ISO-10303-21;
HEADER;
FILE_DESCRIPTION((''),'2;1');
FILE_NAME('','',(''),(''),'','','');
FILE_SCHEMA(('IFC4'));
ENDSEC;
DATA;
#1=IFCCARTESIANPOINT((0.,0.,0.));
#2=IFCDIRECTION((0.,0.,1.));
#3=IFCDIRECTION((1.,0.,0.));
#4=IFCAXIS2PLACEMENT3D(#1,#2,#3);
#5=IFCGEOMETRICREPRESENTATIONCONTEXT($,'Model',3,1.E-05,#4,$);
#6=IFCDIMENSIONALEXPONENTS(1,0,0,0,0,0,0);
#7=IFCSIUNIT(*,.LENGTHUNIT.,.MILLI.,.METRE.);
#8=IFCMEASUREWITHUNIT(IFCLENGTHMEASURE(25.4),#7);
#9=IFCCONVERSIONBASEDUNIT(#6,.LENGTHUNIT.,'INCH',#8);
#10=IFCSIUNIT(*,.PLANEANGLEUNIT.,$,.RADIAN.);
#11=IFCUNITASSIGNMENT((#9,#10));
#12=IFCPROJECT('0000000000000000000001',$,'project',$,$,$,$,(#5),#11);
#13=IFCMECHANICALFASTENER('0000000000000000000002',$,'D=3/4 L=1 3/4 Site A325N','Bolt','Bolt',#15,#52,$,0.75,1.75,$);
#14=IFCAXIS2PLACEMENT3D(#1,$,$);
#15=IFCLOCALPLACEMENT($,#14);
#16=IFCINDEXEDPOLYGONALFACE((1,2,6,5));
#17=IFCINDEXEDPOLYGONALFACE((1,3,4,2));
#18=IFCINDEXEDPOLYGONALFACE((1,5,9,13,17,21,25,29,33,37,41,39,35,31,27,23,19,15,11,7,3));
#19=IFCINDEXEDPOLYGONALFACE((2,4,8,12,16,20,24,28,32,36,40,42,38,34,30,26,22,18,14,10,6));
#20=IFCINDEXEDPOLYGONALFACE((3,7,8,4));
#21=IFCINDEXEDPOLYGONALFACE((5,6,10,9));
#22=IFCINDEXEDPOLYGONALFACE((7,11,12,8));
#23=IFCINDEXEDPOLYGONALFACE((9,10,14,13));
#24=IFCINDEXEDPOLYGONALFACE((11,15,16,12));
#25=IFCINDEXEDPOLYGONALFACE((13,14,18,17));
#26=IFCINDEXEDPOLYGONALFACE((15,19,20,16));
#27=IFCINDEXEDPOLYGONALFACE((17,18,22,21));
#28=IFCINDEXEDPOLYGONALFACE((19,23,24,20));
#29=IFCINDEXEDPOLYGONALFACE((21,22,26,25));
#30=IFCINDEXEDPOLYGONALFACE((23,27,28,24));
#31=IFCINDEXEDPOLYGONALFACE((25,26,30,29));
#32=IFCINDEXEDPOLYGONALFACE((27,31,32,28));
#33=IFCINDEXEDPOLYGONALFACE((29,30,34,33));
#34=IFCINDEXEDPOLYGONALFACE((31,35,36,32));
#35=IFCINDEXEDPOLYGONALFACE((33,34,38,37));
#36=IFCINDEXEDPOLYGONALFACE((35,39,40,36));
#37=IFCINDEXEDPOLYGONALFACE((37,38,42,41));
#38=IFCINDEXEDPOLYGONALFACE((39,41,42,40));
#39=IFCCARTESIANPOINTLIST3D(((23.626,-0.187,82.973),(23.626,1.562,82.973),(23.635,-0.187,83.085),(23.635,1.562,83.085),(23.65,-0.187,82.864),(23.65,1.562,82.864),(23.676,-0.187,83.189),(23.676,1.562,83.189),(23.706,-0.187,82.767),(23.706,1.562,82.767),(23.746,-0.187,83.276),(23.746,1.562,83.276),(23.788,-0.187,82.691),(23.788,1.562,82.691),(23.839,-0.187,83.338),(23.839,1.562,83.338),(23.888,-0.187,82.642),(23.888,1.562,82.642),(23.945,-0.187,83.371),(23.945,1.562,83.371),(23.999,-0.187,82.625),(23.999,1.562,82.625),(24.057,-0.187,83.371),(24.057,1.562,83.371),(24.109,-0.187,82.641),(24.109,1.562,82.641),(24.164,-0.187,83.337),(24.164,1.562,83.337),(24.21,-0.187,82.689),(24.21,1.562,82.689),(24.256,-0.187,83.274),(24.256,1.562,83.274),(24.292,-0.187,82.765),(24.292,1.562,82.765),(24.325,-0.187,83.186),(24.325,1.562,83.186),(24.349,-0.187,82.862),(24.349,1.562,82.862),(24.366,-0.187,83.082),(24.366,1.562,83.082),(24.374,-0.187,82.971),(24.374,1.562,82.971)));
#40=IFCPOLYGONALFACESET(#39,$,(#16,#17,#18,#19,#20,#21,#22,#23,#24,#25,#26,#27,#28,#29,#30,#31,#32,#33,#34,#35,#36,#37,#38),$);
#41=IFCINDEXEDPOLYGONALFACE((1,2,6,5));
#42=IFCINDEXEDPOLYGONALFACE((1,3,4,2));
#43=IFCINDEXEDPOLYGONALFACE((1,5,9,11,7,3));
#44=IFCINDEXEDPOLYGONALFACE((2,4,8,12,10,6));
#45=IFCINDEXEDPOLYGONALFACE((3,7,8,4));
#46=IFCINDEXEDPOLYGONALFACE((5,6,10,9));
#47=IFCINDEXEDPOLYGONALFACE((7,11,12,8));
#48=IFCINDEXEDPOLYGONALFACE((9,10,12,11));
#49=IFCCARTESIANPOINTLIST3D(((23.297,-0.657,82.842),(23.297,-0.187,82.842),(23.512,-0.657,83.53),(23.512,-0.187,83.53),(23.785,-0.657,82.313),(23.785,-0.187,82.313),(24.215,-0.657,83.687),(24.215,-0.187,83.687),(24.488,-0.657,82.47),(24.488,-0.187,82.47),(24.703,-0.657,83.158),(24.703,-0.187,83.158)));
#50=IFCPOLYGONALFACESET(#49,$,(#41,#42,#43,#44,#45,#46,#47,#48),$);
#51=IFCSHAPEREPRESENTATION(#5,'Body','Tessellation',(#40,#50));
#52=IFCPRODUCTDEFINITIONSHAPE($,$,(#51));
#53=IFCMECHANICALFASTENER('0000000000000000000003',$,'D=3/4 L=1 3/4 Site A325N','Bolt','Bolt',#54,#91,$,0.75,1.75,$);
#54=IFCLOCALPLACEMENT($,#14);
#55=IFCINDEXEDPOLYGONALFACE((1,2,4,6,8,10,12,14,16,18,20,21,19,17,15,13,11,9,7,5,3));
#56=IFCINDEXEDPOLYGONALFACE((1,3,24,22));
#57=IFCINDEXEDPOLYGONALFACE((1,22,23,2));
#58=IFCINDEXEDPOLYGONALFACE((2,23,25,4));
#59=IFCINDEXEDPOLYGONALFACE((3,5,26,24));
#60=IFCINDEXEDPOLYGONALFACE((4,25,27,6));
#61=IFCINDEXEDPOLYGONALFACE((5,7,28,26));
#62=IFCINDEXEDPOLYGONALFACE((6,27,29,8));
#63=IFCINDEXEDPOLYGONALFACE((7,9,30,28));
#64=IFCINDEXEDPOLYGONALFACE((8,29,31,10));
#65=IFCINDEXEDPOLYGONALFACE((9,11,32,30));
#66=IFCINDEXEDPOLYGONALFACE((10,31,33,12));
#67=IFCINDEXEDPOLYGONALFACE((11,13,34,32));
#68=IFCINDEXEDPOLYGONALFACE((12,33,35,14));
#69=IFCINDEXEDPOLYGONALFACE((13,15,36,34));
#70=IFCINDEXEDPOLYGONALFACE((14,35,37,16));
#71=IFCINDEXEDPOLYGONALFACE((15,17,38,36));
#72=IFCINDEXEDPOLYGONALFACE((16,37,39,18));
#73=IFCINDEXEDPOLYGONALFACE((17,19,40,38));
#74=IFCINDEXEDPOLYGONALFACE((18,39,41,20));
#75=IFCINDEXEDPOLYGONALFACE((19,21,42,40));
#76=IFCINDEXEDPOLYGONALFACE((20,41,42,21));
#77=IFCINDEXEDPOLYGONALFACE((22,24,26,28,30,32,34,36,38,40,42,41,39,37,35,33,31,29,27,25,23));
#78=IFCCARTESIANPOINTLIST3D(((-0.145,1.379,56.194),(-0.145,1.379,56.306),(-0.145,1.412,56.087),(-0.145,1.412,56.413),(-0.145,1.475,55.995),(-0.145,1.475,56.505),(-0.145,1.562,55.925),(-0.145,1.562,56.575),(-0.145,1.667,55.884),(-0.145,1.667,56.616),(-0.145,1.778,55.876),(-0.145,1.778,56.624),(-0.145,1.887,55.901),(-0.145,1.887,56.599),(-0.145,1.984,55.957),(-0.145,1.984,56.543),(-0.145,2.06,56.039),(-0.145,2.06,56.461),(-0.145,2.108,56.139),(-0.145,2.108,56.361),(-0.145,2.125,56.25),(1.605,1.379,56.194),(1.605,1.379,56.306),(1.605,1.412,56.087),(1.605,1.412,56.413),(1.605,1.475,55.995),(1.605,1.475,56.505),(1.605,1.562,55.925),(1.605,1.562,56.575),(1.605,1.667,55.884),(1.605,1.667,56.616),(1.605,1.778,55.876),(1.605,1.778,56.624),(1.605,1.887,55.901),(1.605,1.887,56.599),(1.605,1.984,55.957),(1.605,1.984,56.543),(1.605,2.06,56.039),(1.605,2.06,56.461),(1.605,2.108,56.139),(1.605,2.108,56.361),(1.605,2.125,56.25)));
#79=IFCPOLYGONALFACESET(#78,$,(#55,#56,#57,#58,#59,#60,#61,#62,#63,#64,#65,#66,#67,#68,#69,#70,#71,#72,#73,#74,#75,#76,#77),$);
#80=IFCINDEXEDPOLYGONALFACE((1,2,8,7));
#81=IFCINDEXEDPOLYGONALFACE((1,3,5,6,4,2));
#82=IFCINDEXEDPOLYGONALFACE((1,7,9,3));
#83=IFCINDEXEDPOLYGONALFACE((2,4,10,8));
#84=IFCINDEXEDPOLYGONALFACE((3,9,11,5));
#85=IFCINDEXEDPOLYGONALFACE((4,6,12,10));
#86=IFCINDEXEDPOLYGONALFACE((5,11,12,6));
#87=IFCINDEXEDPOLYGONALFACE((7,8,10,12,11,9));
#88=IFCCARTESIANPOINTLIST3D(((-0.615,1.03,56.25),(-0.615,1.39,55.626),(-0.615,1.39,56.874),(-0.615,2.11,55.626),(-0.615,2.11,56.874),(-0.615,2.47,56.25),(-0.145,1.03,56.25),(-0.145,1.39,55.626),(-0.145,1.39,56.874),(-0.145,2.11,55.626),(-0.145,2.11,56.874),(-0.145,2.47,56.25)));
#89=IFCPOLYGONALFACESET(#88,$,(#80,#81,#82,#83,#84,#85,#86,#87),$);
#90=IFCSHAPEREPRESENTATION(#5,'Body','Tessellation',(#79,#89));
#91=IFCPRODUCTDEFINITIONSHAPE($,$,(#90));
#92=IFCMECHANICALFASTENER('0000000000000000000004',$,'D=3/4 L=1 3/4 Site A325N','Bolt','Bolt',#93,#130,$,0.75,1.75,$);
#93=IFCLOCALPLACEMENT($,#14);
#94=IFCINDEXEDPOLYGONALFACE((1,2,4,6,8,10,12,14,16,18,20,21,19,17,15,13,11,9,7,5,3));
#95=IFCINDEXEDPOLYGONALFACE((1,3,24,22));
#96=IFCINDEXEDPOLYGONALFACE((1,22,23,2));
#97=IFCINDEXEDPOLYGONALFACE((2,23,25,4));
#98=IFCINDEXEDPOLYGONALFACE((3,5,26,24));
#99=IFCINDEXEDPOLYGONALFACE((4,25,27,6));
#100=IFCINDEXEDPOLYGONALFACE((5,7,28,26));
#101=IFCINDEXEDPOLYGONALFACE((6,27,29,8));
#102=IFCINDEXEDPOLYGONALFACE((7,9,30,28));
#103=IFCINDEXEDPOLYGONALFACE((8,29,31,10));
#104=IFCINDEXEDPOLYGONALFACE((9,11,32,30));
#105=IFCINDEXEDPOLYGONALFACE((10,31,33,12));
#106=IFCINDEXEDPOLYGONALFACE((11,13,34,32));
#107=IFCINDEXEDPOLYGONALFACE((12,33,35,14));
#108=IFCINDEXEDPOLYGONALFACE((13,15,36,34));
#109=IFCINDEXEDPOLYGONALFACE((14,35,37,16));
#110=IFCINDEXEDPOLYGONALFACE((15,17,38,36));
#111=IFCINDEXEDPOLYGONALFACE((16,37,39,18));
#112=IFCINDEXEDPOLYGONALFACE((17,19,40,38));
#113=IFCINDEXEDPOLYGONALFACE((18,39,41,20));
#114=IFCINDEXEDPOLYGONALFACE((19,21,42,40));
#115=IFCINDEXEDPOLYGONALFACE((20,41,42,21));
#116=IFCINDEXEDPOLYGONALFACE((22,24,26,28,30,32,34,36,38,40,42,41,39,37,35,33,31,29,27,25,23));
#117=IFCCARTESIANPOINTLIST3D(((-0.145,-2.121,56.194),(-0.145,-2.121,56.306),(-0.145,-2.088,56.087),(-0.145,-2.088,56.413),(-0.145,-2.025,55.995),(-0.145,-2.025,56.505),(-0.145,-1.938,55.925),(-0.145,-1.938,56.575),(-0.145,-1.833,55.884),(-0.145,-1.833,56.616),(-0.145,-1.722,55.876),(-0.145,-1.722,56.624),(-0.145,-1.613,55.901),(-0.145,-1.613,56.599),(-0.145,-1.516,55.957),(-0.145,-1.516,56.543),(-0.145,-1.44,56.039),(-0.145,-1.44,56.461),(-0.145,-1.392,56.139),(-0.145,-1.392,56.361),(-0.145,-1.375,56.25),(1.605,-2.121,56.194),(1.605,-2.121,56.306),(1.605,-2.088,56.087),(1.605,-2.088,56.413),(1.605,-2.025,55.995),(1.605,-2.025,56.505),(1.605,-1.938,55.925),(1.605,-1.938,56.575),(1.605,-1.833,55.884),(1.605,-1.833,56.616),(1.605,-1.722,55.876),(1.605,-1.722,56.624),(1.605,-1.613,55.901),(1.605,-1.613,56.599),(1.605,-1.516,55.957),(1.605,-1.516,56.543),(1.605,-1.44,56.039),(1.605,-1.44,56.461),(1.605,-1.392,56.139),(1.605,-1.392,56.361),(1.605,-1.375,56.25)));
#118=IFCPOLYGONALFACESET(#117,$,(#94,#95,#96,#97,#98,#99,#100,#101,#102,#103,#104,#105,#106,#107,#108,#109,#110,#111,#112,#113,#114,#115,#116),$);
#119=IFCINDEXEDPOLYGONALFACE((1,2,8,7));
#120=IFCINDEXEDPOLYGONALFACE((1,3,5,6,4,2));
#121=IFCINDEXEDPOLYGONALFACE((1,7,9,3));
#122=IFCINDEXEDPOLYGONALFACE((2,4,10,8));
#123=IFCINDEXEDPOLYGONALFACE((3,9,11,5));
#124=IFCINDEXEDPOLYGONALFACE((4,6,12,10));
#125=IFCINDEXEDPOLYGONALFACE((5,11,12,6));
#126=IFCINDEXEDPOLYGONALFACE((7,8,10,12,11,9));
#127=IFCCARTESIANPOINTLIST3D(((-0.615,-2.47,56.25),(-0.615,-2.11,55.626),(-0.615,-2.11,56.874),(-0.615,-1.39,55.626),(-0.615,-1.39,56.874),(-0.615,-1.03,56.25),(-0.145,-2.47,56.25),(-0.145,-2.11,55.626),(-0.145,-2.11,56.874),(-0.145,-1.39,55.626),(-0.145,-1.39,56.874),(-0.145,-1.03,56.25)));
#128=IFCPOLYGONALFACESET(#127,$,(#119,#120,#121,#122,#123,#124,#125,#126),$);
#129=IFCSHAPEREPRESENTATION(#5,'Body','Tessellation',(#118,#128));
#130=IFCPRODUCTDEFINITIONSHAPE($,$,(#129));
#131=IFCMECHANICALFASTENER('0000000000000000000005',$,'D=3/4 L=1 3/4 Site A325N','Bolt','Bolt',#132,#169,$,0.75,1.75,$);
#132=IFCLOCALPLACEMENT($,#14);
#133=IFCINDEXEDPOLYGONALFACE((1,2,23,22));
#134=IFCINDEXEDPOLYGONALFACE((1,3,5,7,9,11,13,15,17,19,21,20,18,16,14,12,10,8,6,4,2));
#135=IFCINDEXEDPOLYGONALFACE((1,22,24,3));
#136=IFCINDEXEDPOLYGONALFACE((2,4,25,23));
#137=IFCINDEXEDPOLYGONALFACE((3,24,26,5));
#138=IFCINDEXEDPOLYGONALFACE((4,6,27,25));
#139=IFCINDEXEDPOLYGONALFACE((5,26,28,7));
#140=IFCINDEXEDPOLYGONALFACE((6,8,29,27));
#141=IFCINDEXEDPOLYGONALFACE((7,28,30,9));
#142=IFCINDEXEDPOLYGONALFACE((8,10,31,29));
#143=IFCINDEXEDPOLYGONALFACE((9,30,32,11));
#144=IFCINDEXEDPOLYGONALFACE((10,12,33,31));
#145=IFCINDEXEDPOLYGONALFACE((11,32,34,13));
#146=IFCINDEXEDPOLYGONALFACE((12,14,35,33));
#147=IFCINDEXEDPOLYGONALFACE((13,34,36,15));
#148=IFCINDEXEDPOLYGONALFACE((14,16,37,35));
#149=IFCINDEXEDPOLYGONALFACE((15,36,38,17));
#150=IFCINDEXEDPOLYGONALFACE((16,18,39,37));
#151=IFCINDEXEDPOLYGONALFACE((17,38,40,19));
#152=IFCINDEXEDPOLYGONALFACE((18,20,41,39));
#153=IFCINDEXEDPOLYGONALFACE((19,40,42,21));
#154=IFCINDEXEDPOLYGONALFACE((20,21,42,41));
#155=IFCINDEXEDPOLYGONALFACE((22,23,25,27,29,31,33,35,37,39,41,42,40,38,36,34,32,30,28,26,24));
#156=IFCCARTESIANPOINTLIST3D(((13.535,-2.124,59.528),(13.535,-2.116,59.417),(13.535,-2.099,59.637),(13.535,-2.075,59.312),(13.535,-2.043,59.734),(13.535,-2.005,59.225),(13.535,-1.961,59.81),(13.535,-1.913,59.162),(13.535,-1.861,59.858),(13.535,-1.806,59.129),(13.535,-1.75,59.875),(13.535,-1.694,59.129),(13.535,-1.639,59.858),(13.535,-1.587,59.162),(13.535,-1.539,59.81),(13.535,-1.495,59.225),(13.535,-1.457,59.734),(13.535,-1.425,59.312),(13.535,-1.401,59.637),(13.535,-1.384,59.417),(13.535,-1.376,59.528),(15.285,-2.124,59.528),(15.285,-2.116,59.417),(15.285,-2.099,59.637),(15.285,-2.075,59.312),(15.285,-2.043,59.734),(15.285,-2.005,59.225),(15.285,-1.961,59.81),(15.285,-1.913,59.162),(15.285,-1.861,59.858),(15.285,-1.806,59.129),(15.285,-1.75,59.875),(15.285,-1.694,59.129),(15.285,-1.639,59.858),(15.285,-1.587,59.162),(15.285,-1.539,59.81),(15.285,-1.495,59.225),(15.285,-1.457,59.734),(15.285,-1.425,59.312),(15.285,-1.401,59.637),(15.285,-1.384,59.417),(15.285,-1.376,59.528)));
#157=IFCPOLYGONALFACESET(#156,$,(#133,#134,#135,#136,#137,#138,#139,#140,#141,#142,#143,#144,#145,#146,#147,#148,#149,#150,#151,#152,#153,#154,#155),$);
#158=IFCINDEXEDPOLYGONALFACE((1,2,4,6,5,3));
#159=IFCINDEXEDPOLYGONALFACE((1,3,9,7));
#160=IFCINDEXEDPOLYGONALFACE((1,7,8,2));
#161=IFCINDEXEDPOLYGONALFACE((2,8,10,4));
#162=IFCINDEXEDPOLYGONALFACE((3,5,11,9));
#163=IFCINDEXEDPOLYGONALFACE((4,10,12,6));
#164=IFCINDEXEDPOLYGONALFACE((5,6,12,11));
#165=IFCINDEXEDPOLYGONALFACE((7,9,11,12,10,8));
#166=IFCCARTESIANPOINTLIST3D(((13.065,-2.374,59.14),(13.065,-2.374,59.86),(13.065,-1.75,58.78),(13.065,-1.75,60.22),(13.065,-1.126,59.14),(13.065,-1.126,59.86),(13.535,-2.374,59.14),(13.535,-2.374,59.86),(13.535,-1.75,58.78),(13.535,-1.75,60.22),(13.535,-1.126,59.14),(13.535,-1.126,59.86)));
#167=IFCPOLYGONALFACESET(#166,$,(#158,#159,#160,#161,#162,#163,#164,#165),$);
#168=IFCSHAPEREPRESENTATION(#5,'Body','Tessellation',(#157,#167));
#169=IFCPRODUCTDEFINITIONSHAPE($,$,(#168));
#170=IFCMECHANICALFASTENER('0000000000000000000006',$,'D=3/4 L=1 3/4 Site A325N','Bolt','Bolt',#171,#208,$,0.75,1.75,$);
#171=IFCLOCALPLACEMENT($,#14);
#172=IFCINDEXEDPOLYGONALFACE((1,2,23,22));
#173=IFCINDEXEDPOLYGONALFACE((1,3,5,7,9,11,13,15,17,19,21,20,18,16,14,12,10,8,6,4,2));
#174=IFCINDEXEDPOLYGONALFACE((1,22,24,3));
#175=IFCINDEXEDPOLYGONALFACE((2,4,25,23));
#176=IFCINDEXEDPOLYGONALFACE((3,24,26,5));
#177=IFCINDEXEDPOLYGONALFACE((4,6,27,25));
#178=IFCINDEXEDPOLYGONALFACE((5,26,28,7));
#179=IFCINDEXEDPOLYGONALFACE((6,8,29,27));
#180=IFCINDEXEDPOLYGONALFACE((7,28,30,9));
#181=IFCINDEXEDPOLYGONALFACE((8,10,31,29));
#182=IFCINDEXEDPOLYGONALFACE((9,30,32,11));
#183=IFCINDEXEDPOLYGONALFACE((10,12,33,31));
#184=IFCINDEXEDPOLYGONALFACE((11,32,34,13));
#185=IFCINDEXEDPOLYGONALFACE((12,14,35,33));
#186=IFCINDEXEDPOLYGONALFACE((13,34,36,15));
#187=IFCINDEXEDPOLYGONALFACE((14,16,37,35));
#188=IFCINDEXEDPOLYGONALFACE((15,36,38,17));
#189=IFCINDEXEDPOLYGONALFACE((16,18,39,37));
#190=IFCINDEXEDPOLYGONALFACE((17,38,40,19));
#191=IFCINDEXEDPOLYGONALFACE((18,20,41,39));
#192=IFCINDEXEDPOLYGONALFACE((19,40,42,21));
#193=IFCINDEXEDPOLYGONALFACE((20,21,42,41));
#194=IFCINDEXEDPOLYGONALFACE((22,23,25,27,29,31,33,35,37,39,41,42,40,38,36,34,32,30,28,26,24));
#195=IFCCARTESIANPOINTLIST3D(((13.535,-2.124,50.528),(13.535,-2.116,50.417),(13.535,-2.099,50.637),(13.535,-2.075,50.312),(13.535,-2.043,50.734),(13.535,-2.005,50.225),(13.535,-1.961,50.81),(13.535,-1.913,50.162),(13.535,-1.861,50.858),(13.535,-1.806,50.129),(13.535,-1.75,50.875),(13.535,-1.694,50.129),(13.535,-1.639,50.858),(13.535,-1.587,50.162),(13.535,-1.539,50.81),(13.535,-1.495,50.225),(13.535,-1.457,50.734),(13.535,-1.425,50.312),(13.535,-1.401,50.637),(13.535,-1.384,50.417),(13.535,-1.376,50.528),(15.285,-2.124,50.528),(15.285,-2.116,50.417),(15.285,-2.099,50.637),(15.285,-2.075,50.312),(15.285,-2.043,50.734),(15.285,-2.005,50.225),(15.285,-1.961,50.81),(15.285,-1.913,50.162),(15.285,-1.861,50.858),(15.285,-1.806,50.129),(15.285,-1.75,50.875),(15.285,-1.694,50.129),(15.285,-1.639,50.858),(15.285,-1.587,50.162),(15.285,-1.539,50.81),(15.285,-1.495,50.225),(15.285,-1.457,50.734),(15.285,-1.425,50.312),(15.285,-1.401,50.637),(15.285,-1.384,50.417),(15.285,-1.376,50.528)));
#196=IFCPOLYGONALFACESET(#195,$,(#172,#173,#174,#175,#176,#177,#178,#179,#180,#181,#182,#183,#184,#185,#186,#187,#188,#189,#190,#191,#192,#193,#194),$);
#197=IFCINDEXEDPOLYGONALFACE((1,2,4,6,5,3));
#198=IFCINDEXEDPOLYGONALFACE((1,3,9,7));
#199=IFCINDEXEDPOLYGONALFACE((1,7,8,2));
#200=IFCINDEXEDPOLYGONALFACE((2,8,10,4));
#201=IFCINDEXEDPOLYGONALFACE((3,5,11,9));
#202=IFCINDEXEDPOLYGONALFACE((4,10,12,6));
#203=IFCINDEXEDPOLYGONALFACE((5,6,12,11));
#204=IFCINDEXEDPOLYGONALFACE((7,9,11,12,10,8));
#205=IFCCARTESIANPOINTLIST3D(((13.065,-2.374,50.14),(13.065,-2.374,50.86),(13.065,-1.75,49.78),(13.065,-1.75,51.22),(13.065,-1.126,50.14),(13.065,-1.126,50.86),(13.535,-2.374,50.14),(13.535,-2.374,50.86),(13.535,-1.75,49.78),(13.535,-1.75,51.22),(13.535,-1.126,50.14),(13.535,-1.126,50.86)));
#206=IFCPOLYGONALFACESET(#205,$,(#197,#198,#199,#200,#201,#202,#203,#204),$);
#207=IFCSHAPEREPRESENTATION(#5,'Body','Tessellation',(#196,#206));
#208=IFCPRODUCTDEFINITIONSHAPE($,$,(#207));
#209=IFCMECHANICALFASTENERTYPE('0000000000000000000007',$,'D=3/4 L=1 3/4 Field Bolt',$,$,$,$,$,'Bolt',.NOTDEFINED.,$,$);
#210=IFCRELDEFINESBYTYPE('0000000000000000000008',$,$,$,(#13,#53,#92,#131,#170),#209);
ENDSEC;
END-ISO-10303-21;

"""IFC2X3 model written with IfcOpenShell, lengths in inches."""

from ifc_helpers import new_model, entity, si_unit, converted_unit, frame, origin_with_axes, origin_2d_with_axis, place, context, project, polyline, circle, outline, extrude, source, transform, mapped, type_object, type_shapes, element, save


model = new_model("IFC2X3")

# Units and contexts
model_context = context("Model", 3, precision=1e-05, world=origin_with_axes())
ifc_project = project(units=[converted_unit("LENGTHUNIT", "INCH", entity("IfcLengthMeasure", 25.4), si_unit("LENGTHUNIT", "METRE", prefix="MILLI"), dimensions=[1, 0, 0, 0, 0, 0, 0]), si_unit("PLANEANGLEUNIT", "RADIAN")], contexts=[model_context])

# Mechanical fasteners
mechanical_fastener_type_1 = type_object("IfcMechanicalFastenerType", Name="D=3/4 L=1 3/4 Field Bolt", ElementType="Bolt")
shared_shape_1 = source(origin_with_axes(), model_context, "Body", "SweptSolid", [
    extrude(circle(Radius=0.375, at=origin_2d_with_axis()), frame((0.0, 0.0, 0.0), z_axis=(1.0, 0.0, 0.0), x_axis=(0.0, 1.0, 0.0)), (0.0, 0.0, 1.0), 1.75),
    extrude(outline(polyline([(-0.72, 0.0), (-0.36, 0.624), (0.36, 0.624), (0.72, 0.0), (0.36, -0.624), (-0.36, -0.624), (-0.72, 0.0)])), frame((0.0, 0.0, 0.0), z_axis=(1.0, 0.0, 0.0), x_axis=(0.0, 1.0, 0.0)), (0.0, 0.0, -1.0), 0.47),
])
type_shapes(mechanical_fastener_type_1, [shared_shape_1])
placement_1 = place(None, origin_with_axes())
placement_2 = place(placement_1, origin_with_axes())
placement_3 = place(placement_2, frame((24.0, 0.938, 83.0), z_axis=(0.0, 1.0, 0.0), x_axis=(-0.95448, 0.0, 0.298275)))
placement_4 = place(placement_3, frame((0.0, 0.0, -1.125), z_axis=(1.0, 0.0, 0.0), x_axis=(0.0, 0.0, 1.0)))
mechanical_fastener_1_placement = place(placement_4, origin_with_axes())
element("IfcMechanicalFastener", 1, at=mechanical_fastener_1_placement, type_object=mechanical_fastener_type_1, Name="D=3/4 L=1 3/4 Site A325N", Description="Bolt", ObjectType="Bolt", NominalDiameter=0.75, NominalLength=1.75, context=model_context, shape_type="MappedRepresentation", body=[
    mapped(shared_shape_1, transform((0.0, 0.0, 0.0), scale=1.0)),
])
placement_5 = place(placement_2, frame((0.0, 0.0, 54.5), z_axis=(0.0, -1.0, 0.0), x_axis=(0.0, 0.0, 1.0)))
placement_6 = place(placement_5, frame((1.75, 0.145, 1.75), z_axis=(1.0, 0.0, 0.0), x_axis=(0.0, -1.0, 0.0)))
for number, where, z_axis, x_axis, name in (
    (2, (0.0, 3.5, 0.0), (0.0, 0.0, 1.0), (1.0, 0.0, 0.0), "D=3/4 L=1 3/4 Site A325N"),
    (3, (0.0, 0.0, 0.0), (0.0, 0.0, 1.0), (1.0, 0.0, 0.0), "D=3/4 L=1 3/4 Site A325N"),
):
    element("IfcMechanicalFastener", number, at=place(placement_6, frame(where, z_axis=z_axis, x_axis=x_axis)), type_object=mechanical_fastener_type_1, Name=name, Description="Bolt", ObjectType="Bolt", NominalDiameter=0.75, NominalLength=1.75, context=model_context, shape_type="MappedRepresentation", body=[
        mapped(shared_shape_1, transform((0.0, 0.0, 0.0), scale=1.0)),
    ])
placement_7 = place(placement_2, frame((36.0, 0.0, 58.0), z_axis=(0.0, 0.0, 1.0), x_axis=(-1.0, 0.0, 0.0)))
placement_8 = place(placement_7, frame((22.465, 1.75, 1.5), z_axis=(0.0, 1.0, 0.0), x_axis=(-1.0, 0.0, 0.0)))
for number, where, z_axis, x_axis, name in (
    (4, (0.0, 0.0, 0.0), (0.0, 0.0, 1.0), (1.0, 0.0, 0.0), "D=3/4 L=1 3/4 Site A325N"),
    (5, (0.0, -9.0, 0.0), (0.0, 0.0, 1.0), (1.0, 0.0, 0.0), "D=3/4 L=1 3/4 Site A325N"),
):
    element("IfcMechanicalFastener", number, at=place(placement_8, frame(where, z_axis=z_axis, x_axis=x_axis)), type_object=mechanical_fastener_type_1, Name=name, Description="Bolt", ObjectType="Bolt", NominalDiameter=0.75, NominalLength=1.75, context=model_context, shape_type="MappedRepresentation", body=[
        mapped(shared_shape_1, transform((0.0, 0.0, 0.0), scale=1.0)),
    ])

save(model, "model.ifc")
